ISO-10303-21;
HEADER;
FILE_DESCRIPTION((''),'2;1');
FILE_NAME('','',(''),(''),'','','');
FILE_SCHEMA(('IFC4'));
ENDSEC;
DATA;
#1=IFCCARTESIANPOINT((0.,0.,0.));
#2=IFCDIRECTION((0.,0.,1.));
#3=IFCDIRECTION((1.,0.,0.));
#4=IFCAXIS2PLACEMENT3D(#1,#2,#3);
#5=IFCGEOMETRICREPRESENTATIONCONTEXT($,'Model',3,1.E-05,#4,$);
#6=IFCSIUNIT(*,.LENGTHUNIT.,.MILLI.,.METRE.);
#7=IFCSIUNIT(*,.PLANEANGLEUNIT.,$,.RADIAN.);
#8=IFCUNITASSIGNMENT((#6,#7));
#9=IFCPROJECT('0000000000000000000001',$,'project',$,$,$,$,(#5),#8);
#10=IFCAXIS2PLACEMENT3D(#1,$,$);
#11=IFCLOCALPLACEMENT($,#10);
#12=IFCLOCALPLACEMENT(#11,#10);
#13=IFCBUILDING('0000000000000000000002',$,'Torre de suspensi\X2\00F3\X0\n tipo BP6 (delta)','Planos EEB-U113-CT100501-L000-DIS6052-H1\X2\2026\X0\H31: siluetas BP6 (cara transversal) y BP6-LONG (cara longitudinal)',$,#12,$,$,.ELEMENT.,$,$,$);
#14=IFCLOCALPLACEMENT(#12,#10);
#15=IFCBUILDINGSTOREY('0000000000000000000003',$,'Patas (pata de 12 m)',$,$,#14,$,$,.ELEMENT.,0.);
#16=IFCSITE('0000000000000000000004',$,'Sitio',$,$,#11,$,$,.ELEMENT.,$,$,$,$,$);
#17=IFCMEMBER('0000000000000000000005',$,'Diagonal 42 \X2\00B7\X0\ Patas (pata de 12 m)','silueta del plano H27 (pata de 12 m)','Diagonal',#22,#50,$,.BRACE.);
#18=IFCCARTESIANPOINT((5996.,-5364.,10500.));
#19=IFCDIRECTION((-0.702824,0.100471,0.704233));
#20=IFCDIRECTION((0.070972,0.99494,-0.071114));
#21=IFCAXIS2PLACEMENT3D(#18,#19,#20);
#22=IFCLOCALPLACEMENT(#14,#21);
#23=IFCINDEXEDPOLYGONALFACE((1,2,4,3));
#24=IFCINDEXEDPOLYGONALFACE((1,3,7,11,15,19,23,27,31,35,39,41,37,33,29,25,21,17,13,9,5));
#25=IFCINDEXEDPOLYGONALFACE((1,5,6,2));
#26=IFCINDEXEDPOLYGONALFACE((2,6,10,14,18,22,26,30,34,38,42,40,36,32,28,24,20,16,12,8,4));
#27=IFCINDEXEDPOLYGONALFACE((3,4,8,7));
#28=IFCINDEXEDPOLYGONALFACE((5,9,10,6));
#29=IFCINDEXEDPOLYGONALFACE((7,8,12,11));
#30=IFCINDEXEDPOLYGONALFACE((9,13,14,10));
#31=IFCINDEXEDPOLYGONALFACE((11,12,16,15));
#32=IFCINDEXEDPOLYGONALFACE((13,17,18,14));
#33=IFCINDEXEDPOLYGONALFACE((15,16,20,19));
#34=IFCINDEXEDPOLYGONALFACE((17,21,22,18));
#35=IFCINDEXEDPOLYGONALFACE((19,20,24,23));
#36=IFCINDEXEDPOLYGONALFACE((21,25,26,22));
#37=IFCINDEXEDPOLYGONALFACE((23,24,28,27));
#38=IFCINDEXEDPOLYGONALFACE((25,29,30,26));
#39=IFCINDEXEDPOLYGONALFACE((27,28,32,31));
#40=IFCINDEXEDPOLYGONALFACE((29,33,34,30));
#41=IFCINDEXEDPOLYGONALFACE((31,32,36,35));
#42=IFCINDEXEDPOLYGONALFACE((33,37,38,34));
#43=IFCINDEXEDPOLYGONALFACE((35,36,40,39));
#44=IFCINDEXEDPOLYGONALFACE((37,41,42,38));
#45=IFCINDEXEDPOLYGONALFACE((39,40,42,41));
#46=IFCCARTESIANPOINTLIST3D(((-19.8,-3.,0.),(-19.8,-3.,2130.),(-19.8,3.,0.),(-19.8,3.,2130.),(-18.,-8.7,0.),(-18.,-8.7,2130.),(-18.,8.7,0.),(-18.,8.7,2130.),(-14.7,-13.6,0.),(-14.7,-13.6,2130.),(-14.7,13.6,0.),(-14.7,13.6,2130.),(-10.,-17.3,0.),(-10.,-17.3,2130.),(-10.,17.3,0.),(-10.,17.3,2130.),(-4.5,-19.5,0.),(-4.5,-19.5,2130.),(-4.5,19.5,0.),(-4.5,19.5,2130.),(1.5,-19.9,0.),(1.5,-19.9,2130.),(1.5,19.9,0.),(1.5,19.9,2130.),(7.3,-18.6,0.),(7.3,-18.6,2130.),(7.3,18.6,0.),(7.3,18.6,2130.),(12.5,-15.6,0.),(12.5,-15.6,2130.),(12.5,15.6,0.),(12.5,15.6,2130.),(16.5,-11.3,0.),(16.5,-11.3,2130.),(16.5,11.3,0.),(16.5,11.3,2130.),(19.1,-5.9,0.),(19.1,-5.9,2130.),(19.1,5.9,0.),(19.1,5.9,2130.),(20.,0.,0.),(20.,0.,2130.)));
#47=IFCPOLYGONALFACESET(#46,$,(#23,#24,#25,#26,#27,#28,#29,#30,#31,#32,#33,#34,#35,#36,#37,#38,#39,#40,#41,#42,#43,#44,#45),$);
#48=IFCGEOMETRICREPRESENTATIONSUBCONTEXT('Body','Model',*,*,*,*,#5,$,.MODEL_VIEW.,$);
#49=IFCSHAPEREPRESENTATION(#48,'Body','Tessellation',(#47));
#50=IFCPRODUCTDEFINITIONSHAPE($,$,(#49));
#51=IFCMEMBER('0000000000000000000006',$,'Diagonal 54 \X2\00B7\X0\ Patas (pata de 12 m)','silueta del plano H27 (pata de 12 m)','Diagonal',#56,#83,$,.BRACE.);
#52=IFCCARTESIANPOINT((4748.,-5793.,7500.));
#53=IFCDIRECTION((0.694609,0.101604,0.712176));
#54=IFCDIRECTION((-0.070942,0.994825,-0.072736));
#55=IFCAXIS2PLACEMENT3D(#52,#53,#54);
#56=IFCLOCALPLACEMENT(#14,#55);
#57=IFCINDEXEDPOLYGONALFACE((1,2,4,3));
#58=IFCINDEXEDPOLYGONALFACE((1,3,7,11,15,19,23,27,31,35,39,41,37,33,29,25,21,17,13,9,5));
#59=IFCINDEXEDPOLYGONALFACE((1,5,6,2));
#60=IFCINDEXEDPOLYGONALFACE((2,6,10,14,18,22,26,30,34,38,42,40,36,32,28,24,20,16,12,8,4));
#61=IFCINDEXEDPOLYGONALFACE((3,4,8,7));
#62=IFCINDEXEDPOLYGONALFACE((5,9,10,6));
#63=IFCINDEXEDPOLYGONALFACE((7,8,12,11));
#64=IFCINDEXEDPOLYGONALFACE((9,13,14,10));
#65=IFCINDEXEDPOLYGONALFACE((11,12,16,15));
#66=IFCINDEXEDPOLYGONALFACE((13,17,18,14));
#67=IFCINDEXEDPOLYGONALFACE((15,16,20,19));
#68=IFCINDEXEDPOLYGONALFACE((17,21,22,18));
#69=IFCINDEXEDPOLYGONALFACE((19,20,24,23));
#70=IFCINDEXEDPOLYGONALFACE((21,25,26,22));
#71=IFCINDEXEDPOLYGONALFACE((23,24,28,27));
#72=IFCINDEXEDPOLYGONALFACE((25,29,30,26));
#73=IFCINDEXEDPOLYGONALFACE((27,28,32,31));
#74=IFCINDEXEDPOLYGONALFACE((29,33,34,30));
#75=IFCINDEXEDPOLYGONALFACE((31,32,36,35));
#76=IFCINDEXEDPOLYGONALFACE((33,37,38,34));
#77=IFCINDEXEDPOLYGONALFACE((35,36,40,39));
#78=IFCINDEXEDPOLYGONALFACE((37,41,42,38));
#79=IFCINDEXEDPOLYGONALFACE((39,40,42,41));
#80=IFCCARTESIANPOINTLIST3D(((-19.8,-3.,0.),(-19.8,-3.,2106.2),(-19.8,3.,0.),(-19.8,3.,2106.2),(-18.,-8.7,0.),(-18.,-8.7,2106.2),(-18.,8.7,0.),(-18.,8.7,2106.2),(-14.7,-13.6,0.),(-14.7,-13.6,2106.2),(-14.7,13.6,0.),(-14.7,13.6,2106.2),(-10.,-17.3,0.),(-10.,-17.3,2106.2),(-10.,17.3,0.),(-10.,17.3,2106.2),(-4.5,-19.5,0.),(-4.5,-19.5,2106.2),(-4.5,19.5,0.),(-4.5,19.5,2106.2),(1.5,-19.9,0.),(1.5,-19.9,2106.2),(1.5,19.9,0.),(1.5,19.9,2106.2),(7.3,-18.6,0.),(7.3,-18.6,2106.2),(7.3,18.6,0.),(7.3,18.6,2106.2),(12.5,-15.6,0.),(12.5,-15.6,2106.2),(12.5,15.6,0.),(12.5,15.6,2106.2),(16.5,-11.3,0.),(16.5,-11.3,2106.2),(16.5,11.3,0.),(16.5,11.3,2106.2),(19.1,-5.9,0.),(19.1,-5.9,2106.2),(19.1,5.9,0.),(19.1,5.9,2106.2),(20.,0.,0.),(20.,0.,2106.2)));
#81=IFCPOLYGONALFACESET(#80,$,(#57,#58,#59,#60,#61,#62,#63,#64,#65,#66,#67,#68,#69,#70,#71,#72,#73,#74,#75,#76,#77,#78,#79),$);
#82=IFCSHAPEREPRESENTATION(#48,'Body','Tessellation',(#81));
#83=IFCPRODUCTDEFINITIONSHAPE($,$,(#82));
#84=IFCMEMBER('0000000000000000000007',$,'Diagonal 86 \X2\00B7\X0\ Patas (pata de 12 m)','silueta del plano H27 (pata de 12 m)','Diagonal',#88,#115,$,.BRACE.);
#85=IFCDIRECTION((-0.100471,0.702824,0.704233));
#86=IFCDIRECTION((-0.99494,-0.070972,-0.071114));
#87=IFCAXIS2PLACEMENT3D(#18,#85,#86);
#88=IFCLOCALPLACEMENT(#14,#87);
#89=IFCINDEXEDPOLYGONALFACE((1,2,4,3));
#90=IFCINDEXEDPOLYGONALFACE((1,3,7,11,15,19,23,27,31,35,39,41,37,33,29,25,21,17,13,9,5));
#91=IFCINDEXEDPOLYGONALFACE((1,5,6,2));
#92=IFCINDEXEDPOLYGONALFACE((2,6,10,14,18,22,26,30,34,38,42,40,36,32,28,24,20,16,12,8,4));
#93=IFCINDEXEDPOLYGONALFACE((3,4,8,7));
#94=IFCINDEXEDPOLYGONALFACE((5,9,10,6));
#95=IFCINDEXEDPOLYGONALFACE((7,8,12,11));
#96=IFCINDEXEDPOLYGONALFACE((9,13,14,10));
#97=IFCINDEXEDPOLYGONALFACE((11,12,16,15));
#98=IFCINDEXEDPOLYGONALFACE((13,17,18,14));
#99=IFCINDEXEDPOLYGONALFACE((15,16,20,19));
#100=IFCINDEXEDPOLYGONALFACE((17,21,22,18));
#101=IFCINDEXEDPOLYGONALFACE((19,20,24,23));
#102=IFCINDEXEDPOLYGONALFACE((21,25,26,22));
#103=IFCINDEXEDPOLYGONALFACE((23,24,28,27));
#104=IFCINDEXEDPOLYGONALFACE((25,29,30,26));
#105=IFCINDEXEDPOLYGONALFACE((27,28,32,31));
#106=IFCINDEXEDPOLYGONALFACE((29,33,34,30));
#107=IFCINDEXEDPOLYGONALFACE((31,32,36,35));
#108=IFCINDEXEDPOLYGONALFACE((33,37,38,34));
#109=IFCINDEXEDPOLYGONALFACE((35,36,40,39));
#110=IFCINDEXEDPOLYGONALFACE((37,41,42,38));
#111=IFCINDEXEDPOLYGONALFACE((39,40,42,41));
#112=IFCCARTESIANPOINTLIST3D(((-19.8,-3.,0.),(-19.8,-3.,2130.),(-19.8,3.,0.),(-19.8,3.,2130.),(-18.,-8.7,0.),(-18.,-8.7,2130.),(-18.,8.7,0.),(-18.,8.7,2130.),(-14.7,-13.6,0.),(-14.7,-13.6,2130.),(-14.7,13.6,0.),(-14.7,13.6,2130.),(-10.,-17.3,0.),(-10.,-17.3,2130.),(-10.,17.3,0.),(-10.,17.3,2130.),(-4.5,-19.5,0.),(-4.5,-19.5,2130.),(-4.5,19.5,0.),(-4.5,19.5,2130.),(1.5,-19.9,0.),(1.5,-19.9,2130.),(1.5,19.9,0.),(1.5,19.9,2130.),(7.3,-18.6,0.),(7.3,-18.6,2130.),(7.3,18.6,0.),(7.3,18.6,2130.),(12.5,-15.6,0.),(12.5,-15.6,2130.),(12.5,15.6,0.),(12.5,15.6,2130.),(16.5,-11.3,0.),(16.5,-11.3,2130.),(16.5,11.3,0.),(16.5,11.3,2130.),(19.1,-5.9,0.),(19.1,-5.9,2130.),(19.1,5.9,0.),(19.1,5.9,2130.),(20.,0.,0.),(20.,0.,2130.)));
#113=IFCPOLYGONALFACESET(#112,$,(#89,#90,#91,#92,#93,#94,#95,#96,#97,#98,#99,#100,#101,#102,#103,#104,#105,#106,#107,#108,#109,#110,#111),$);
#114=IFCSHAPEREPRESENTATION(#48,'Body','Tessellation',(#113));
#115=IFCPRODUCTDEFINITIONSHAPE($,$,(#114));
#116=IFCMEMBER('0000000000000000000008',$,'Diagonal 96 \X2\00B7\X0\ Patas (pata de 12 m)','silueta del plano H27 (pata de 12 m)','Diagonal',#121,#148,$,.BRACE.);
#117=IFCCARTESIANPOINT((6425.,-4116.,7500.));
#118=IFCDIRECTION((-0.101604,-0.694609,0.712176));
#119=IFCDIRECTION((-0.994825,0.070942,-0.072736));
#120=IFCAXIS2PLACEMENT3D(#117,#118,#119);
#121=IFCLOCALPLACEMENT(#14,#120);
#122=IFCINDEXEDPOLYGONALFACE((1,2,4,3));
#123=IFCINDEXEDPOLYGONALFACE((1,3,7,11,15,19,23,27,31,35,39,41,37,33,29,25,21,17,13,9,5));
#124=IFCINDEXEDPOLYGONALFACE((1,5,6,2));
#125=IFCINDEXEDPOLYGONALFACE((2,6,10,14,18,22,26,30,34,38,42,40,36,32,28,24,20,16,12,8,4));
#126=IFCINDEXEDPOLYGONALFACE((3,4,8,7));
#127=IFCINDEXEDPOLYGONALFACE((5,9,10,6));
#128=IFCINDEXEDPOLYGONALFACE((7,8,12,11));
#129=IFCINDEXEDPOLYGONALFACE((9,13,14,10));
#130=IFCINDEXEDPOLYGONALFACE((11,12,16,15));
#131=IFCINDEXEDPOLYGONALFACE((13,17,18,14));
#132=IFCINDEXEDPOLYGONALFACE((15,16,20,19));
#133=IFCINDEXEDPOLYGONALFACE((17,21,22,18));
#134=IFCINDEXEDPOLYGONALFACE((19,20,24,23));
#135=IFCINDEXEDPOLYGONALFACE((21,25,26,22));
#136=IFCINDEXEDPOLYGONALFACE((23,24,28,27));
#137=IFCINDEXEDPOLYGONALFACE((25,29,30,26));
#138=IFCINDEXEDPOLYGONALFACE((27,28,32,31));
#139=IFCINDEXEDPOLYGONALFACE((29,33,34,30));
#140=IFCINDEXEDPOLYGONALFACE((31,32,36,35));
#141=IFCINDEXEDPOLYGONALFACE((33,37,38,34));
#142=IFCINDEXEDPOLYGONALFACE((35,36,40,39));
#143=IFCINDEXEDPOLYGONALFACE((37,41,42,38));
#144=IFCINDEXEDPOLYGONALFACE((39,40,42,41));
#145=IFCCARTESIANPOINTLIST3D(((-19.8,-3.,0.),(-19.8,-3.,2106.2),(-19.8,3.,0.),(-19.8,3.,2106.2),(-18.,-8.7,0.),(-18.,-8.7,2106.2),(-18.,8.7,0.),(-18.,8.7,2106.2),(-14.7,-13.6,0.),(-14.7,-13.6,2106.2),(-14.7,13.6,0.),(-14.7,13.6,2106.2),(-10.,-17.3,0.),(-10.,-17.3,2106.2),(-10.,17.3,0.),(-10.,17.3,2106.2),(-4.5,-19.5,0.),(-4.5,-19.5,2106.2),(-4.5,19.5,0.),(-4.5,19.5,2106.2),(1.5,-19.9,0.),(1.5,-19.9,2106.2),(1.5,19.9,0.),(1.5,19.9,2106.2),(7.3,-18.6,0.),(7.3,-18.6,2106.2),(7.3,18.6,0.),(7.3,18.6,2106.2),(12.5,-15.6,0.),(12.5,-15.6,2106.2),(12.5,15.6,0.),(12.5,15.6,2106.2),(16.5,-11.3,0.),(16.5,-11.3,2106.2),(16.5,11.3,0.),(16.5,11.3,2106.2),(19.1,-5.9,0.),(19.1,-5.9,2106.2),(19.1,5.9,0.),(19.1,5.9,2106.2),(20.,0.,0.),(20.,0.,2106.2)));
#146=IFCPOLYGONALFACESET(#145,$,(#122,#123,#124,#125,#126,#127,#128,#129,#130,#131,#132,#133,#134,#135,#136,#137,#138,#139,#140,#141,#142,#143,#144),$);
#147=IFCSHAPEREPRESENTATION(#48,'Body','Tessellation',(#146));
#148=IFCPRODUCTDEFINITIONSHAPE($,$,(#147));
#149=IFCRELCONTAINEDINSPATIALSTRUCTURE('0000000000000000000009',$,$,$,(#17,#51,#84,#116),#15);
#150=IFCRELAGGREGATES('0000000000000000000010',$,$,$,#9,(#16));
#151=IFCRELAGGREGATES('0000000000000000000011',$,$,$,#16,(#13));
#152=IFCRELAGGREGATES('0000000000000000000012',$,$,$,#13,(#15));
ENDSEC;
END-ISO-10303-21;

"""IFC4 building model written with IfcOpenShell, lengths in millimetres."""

from ifc_helpers import new_model, si_unit, frame, origin, origin_with_axes, place, context, subcontext, project, spatial, circle, extrude, element, save


model = new_model("IFC4")

# Units and contexts
model_context = context("Model", 3, precision=1e-05, world=origin_with_axes())
body_context = subcontext(model_context, "Body", "Model", "MODEL_VIEW")
ifc_project = project(units=[si_unit("LENGTHUNIT", "METRE", prefix="MILLI"), si_unit("PLANEANGLEUNIT", "RADIAN")], contexts=[model_context])

# Site, building, storey
site_placement = place(None, origin())
site = spatial("IfcSite", under=ifc_project, at=site_placement, Name="Sitio", CompositionType="ELEMENT")
building_placement = place(site_placement, origin())
building = spatial("IfcBuilding", under=site, at=building_placement, Name="Torre de suspensión tipo BP6 (delta)", Description="Planos EEB-U113-CT100501-L000-DIS6052-H1…H31: siluetas BP6 (cara transversal) y BP6-LONG (cara longitudinal)", CompositionType="ELEMENT")
storey_placement = place(building_placement, origin())
storey = spatial("IfcBuildingStorey", under=building, at=storey_placement, Name="Patas (pata de 12 m)", CompositionType="ELEMENT", Elevation=0.0)

# Members
member_1_placement = place(storey_placement, frame((5996.0, -5364.0, 10500.0), z_axis=(-0.702824, 0.100471, 0.704233), x_axis=(0.070972, 0.99494, -0.071114)))
element("IfcMember", 1, at=member_1_placement, inside=storey, Name="Diagonal 42 · Patas (pata de 12 m)", Description="silueta del plano H27 (pata de 12 m)", ObjectType="Diagonal", PredefinedType="BRACE", context=body_context, shape_type="SweptSolid", body=[
    extrude(circle(Radius=20.0), None, (0.0, 0.0, 1.0), 2130.0),
])
member_2_placement = place(storey_placement, frame((4748.0, -5793.0, 7500.0), z_axis=(0.694609, 0.101604, 0.712176), x_axis=(-0.070942, 0.994825, -0.072736)))
element("IfcMember", 2, at=member_2_placement, inside=storey, Name="Diagonal 54 · Patas (pata de 12 m)", Description="silueta del plano H27 (pata de 12 m)", ObjectType="Diagonal", PredefinedType="BRACE", context=body_context, shape_type="SweptSolid", body=[
    extrude(circle(Radius=20.0), None, (0.0, 0.0, 1.0), 2106.2),
])
member_3_placement = place(storey_placement, frame((5996.0, -5364.0, 10500.0), z_axis=(-0.100471, 0.702824, 0.704233), x_axis=(-0.99494, -0.070972, -0.071114)))
element("IfcMember", 3, at=member_3_placement, inside=storey, Name="Diagonal 86 · Patas (pata de 12 m)", Description="silueta del plano H27 (pata de 12 m)", ObjectType="Diagonal", PredefinedType="BRACE", context=body_context, shape_type="SweptSolid", body=[
    extrude(circle(Radius=20.0), None, (0.0, 0.0, 1.0), 2130.0),
])
member_4_placement = place(storey_placement, frame((6425.0, -4116.0, 7500.0), z_axis=(-0.101604, -0.694609, 0.712176), x_axis=(-0.994825, 0.070942, -0.072736)))
element("IfcMember", 4, at=member_4_placement, inside=storey, Name="Diagonal 96 · Patas (pata de 12 m)", Description="silueta del plano H27 (pata de 12 m)", ObjectType="Diagonal", PredefinedType="BRACE", context=body_context, shape_type="SweptSolid", body=[
    extrude(circle(Radius=20.0), None, (0.0, 0.0, 1.0), 2106.2),
])

save(model, "model.ifc")
